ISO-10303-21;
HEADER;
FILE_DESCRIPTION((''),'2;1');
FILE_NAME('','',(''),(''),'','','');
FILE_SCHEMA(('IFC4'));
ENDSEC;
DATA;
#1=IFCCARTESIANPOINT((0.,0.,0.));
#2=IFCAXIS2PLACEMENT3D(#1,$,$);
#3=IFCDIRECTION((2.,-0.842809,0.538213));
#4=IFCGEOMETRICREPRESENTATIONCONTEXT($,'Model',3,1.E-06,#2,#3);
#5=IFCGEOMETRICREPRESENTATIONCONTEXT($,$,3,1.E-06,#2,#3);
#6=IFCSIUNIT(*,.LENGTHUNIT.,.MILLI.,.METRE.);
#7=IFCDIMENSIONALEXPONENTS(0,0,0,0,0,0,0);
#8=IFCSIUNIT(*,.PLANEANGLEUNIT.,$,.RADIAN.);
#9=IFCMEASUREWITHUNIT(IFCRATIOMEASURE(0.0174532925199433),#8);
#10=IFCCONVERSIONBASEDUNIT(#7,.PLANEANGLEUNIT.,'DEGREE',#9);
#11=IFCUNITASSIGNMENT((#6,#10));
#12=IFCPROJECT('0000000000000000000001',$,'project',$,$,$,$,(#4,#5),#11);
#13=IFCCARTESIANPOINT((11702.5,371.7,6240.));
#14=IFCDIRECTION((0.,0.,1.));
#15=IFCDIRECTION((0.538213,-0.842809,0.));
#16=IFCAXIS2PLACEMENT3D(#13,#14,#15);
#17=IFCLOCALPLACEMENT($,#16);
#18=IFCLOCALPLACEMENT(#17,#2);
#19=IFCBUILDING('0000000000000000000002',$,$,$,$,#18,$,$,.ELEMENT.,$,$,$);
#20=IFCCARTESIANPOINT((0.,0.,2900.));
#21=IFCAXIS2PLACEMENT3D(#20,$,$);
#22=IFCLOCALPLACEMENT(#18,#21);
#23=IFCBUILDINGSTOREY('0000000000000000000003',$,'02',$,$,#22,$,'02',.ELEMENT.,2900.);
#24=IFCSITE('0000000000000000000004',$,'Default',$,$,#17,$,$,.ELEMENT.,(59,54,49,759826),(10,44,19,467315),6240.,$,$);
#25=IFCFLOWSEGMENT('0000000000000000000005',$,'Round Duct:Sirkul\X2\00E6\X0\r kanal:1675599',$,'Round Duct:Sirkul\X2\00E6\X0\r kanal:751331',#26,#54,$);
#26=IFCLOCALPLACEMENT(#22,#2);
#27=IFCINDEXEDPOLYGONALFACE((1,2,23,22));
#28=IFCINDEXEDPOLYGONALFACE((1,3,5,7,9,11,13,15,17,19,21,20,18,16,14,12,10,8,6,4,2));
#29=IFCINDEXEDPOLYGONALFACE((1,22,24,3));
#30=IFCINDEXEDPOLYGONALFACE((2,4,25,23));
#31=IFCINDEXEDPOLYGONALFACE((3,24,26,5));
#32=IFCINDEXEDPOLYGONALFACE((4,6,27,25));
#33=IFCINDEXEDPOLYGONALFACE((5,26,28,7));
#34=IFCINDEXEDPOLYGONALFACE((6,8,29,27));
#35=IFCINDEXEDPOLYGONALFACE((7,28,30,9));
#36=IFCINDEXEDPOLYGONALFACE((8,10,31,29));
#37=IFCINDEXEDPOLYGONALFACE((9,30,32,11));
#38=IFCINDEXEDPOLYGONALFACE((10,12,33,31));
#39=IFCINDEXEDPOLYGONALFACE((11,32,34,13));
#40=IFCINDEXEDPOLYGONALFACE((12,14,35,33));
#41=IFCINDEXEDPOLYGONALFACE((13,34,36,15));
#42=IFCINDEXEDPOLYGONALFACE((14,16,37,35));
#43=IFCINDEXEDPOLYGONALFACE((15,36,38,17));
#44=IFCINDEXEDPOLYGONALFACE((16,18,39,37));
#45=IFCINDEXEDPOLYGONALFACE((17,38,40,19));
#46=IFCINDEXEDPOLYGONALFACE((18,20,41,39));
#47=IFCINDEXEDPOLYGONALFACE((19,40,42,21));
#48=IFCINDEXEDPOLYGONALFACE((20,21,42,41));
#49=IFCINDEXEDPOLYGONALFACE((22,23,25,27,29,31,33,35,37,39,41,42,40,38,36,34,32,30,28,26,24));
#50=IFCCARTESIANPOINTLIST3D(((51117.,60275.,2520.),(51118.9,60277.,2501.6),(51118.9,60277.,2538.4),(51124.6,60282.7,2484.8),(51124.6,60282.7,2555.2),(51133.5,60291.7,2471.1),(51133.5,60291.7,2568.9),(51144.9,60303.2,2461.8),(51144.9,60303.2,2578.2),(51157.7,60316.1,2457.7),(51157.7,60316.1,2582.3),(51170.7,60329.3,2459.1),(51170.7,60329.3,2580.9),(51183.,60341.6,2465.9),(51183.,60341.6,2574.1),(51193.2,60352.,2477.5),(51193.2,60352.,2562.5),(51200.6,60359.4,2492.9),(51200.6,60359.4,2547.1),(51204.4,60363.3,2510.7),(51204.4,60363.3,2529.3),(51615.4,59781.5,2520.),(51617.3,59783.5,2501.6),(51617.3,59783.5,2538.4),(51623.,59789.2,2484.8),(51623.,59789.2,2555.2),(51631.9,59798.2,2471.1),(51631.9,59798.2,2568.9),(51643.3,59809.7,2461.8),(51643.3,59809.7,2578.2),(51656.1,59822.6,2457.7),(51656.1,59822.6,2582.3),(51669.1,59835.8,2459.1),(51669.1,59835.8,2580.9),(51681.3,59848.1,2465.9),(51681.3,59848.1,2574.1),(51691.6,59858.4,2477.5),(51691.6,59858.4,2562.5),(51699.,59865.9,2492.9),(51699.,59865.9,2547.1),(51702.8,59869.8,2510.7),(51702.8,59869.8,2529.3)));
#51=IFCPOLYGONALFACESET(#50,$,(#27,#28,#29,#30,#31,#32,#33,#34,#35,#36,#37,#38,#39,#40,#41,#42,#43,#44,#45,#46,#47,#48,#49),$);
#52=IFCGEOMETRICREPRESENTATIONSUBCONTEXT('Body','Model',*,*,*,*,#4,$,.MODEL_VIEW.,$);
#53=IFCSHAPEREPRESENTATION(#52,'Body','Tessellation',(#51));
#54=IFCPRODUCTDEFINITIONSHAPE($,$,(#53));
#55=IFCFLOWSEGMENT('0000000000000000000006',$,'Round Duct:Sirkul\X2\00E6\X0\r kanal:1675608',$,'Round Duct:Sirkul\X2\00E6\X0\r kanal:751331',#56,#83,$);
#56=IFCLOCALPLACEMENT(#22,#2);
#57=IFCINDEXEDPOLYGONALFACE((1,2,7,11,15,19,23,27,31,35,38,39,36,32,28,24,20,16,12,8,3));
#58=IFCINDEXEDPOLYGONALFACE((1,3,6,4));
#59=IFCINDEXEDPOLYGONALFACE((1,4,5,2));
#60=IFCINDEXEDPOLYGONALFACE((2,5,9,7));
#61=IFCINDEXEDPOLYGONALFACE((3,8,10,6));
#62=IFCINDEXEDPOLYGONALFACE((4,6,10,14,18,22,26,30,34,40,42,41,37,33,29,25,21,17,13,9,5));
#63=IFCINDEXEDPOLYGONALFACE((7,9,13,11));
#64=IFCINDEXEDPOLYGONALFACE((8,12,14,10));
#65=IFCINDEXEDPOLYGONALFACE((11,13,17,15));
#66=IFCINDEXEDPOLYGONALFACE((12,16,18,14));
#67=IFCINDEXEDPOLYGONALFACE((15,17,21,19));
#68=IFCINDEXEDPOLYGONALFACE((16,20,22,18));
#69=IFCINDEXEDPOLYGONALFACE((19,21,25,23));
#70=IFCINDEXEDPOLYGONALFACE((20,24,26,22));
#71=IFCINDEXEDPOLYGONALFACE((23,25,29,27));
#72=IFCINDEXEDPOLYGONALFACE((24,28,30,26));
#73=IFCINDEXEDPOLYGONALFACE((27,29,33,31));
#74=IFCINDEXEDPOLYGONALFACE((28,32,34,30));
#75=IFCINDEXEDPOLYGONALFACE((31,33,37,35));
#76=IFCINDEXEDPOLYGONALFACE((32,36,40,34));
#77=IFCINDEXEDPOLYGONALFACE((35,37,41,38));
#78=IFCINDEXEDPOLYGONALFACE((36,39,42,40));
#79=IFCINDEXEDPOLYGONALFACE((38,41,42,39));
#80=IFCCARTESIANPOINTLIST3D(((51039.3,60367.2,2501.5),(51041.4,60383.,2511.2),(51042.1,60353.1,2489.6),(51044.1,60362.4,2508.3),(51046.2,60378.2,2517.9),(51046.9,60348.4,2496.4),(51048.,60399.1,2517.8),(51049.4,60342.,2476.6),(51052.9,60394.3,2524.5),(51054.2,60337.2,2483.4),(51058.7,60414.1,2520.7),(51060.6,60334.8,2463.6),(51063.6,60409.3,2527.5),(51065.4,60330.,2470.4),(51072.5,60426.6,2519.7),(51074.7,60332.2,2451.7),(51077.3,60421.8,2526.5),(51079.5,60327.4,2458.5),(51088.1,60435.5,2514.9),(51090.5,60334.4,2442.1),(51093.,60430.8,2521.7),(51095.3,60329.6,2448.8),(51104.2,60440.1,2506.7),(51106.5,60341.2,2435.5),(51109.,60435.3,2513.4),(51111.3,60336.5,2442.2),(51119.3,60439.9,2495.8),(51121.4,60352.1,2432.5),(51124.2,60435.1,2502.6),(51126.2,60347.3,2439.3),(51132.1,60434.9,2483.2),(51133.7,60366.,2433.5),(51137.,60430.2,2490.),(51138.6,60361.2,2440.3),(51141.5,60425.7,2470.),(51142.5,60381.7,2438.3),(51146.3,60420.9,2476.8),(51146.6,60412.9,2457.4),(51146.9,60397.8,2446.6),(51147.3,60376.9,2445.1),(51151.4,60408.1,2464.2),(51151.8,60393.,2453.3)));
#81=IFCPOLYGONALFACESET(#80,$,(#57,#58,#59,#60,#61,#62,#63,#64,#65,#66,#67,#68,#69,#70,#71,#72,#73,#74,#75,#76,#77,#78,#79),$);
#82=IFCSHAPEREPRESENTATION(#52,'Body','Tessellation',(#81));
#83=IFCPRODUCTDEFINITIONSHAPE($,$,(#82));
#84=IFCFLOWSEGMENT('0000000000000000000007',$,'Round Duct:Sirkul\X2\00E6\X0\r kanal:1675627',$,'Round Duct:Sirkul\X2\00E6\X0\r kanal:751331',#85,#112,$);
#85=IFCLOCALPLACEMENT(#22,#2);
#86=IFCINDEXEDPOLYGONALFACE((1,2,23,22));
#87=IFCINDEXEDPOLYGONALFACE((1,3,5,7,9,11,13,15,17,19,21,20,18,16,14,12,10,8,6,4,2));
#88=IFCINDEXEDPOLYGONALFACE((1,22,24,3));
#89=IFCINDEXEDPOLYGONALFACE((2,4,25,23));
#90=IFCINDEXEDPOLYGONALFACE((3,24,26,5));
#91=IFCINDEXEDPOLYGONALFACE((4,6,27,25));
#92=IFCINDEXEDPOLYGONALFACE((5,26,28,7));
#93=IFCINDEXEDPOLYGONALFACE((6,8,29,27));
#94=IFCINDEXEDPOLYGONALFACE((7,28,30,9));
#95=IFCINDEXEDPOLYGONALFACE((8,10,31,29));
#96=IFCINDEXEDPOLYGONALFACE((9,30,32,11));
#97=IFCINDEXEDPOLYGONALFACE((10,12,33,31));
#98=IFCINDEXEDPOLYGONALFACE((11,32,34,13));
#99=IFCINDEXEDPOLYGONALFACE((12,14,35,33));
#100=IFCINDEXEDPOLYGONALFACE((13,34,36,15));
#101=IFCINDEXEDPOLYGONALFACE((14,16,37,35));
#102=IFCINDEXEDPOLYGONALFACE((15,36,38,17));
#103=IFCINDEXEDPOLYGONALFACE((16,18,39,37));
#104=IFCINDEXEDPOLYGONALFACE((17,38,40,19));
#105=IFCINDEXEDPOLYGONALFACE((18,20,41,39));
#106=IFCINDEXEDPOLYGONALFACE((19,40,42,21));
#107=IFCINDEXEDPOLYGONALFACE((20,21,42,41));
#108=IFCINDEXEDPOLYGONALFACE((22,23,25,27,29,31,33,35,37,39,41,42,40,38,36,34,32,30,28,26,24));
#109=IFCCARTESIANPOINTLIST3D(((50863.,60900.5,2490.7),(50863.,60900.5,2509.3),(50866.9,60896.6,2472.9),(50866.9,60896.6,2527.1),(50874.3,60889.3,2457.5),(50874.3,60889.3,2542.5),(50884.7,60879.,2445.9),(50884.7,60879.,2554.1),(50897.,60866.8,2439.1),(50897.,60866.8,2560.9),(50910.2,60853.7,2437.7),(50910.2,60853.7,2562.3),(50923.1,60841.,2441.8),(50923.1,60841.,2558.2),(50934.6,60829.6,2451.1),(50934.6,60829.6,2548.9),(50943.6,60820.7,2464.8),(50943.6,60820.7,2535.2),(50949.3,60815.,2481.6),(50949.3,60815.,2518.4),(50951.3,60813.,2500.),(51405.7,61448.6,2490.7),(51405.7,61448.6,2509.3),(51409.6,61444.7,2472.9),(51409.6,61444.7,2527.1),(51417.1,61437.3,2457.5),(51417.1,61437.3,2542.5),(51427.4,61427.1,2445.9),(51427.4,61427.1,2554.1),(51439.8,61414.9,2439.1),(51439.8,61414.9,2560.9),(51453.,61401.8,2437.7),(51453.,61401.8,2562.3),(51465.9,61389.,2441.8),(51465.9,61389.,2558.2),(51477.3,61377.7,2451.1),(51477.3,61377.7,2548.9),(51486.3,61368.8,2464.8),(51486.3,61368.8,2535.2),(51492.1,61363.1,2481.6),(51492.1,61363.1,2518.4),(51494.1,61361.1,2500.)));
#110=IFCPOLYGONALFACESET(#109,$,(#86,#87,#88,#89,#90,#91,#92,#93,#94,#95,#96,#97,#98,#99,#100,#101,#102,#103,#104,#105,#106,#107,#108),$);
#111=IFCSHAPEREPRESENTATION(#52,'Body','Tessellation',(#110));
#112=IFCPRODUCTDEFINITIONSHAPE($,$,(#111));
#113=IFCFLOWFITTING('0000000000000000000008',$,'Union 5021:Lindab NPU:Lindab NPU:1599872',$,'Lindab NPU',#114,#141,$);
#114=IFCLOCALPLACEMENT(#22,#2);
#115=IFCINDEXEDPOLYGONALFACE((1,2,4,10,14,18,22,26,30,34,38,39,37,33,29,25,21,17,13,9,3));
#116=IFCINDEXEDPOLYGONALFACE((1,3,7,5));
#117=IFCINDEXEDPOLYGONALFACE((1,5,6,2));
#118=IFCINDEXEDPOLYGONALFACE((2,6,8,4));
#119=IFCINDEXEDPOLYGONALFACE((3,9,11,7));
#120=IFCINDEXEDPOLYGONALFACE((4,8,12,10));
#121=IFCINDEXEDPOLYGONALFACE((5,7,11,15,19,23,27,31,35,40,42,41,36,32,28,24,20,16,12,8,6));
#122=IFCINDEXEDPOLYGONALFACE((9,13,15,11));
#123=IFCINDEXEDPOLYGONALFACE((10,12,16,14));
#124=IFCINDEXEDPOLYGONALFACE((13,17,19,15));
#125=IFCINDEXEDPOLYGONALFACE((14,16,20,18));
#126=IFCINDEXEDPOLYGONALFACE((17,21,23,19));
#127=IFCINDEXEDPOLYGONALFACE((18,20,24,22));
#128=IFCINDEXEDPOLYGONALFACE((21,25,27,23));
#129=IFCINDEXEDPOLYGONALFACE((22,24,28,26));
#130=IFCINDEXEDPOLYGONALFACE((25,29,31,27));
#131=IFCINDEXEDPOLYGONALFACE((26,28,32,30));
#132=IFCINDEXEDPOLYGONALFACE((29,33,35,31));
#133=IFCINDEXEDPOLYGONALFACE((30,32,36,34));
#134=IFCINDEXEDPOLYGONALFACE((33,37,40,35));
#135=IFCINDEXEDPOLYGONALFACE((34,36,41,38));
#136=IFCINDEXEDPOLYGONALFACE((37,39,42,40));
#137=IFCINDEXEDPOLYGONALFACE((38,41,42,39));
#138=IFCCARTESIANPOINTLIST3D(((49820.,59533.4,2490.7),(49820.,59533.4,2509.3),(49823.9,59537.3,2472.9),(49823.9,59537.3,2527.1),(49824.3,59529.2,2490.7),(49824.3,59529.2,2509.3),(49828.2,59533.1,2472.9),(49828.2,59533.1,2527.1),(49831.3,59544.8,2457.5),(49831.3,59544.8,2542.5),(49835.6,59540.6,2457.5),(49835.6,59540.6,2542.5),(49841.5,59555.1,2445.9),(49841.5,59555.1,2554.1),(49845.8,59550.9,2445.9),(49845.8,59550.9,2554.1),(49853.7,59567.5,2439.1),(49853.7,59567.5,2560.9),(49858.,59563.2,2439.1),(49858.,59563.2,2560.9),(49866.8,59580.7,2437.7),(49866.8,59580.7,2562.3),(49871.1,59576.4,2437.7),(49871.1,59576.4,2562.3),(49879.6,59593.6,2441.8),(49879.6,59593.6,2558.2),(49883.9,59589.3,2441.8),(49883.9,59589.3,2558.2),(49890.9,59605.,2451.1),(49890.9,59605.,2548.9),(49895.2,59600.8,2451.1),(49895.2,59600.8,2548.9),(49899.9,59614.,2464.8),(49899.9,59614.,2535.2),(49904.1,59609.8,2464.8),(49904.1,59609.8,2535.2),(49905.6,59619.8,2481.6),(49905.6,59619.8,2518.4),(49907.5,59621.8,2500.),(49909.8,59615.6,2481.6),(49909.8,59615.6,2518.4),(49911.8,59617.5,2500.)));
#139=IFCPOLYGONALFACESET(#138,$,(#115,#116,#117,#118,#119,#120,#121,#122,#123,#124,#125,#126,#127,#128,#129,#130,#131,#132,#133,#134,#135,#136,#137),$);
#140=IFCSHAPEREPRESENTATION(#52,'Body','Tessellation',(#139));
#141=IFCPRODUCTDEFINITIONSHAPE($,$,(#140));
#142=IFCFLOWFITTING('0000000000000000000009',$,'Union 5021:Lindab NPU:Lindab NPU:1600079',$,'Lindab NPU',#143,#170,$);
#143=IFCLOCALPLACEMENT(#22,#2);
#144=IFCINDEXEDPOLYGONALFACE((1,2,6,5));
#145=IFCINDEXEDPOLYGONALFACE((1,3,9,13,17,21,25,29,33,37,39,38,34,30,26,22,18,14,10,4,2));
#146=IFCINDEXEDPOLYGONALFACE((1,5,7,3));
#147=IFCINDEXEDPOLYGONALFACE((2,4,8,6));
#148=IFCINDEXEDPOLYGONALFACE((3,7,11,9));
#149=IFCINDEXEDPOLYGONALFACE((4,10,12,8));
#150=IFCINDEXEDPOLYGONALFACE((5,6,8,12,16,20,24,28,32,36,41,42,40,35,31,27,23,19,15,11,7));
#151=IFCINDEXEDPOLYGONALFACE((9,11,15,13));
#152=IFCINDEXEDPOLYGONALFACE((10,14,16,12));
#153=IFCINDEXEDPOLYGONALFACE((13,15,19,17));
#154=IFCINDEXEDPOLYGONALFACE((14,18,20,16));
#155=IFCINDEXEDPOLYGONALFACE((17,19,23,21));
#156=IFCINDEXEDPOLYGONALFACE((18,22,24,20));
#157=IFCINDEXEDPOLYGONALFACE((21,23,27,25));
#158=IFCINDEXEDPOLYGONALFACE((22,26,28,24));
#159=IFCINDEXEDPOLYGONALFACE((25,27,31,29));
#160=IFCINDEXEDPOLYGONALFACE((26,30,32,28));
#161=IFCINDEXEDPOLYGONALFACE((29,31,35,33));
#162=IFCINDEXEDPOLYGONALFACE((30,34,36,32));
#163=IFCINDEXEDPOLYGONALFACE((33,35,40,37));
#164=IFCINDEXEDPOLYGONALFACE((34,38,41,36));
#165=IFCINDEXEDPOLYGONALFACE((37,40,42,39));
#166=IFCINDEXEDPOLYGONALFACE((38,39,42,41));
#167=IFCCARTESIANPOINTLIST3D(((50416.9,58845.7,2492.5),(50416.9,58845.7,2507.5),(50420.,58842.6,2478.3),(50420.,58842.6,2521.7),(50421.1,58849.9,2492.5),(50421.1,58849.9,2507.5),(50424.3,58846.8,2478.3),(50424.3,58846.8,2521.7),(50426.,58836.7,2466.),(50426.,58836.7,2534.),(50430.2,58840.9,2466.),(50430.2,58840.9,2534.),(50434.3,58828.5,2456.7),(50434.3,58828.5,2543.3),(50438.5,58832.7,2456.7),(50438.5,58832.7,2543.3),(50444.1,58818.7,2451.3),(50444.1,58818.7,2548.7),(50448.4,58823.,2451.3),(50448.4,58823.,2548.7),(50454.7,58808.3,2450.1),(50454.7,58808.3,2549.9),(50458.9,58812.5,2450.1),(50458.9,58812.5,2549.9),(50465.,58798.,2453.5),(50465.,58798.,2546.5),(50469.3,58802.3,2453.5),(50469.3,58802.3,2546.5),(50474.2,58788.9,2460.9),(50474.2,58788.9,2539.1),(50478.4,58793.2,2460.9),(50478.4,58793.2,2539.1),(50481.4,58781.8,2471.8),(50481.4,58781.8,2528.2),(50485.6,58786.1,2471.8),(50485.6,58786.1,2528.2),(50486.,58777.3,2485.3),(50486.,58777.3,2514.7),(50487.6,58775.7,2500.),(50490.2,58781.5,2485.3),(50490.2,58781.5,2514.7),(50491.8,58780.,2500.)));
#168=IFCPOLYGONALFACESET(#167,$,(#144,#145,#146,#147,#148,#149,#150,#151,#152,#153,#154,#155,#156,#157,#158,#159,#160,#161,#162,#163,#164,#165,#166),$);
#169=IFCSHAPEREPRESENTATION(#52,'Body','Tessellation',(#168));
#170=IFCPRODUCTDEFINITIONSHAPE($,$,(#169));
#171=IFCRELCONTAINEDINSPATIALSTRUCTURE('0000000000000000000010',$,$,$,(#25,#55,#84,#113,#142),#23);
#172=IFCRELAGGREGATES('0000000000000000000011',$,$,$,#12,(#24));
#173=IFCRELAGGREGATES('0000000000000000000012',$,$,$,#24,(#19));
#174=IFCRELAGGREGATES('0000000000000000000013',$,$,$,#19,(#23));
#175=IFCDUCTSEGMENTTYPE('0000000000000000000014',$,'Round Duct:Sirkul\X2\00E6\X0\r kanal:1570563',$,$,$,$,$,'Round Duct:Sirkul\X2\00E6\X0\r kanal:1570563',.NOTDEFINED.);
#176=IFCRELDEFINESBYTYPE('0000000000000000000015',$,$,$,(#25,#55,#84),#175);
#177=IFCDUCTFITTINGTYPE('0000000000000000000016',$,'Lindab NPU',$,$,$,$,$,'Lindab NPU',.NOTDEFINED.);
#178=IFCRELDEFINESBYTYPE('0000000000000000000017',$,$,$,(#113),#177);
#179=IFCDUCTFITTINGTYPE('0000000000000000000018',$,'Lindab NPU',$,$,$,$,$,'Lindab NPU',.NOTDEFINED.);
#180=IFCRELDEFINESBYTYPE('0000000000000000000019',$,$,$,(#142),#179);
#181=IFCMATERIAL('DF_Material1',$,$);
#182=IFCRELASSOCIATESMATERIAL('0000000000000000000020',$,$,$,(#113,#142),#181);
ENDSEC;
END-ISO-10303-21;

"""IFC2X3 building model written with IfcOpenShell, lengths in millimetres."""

from ifc_helpers import new_model, entity, si_unit, converted_unit, direction, frame, frame_2d, origin, origin_2d_with_axis, place, context, subcontext, project, spatial, circle, extrude, source, transform, mapped, material, type_object, type_shapes, element, save


model = new_model("IFC2X3")

# Units and contexts
model_context = context("Model", 3, precision=1e-06, world=origin(), true_north=direction((2.0, -0.842809, 0.538213)))
context_of_model = context(None, 3, precision=1e-06, world=origin(), true_north=direction((2.0, -0.842809, 0.538213)))
body_context = subcontext(model_context, "Body", "Model", "MODEL_VIEW")
ifc_project = project(units=[si_unit("LENGTHUNIT", "METRE", prefix="MILLI"), converted_unit("PLANEANGLEUNIT", "DEGREE", entity("IfcRatioMeasure", 0.0174532925199433), si_unit("PLANEANGLEUNIT", "RADIAN"), dimensions=[0, 0, 0, 0, 0, 0, 0])], contexts=[model_context, context_of_model])

# Site, building, storey
site_placement = place(None, frame((11702.5, 371.7, 6240.0), z_axis=(0.0, 0.0, 1.0), x_axis=(0.538213, -0.842809, 0.0)))
site = spatial("IfcSite", under=ifc_project, at=site_placement, Name="Default", CompositionType="ELEMENT", RefLatitude=(59, 54, 49, 759826), RefLongitude=(10, 44, 19, 467315), RefElevation=6240.0)
building_placement = place(site_placement, origin())
building = spatial("IfcBuilding", under=site, at=building_placement, CompositionType="ELEMENT")
storey_placement = place(building_placement, frame((0.0, 0.0, 2900.0)))
storey = spatial("IfcBuildingStorey", under=building, at=storey_placement, Name="02", LongName="02", CompositionType="ELEMENT", Elevation=2900.0)

# Flow segments
duct_segment_type_1 = type_object("IfcDuctSegmentType", Name="Round Duct:Sirkulær kanal:1570563", ElementType="Round Duct:Sirkulær kanal:1570563", PredefinedType="NOTDEFINED")
flow_segment_1_placement = place(storey_placement, origin())
element("IfcFlowSegment", 1, at=flow_segment_1_placement, inside=storey, type_object=duct_segment_type_1, Name="Round Duct:Sirkulær kanal:1675599", ObjectType="Round Duct:Sirkulær kanal:751331", context=body_context, shape_type="SweptSolid", body=[
    extrude(circle(Radius=62.5, at=origin_2d_with_axis()), frame((51659.3, 59825.9, 2520.0), z_axis=(-0.710554, 0.703643, 0.0), x_axis=(-0.703643, -0.710554, 0.0)), (0.0, 0.0, 1.0), 701.4),
])
flow_segment_2_placement = place(storey_placement, origin())
element("IfcFlowSegment", 2, at=flow_segment_2_placement, inside=storey, type_object=duct_segment_type_1, Name="Round Duct:Sirkulær kanal:1675608", ObjectType="Round Duct:Sirkulær kanal:751331", context=body_context, shape_type="SweptSolid", body=[
    extrude(circle(Radius=62.5, at=origin_2d_with_axis()), frame((51093.3, 60386.4, 2476.6), z_axis=(0.502437, -0.49755, 0.707107), x_axis=(-0.703643, -0.710554, 0.0)), (0.0, 0.0, 1.0), 9.6),
])
flow_segment_3_placement = place(storey_placement, origin())
element("IfcFlowSegment", 3, at=flow_segment_3_placement, inside=storey, type_object=duct_segment_type_1, Name="Round Duct:Sirkulær kanal:1675627", ObjectType="Round Duct:Sirkulær kanal:751331", context=body_context, shape_type="SweptSolid", body=[
    extrude(circle(Radius=62.5, at=origin_2d_with_axis()), frame((50906.9, 60857.0, 2500.0), z_axis=(0.703643, 0.710554, 0.0), x_axis=(0.710554, -0.703643, 0.0)), (0.0, 0.0, 1.0), 771.3),
])

# Flow fittings
ifc_material = material(Name="DF_Material1")
duct_fitting_type_1 = type_object("IfcDuctFittingType", Name="Lindab NPU", ElementType="Lindab NPU", PredefinedType="NOTDEFINED")
shared_shape_1 = source(origin(), body_context, "Body", "SweptSolid", [
    extrude(circle(Radius=62.5, at=frame_2d((0.0, 0.0), x_axis=(1.0, 0.0))), frame((0.0, 0.0, 0.0), z_axis=(1.0, 0.0, 0.0), x_axis=(0.0, 1.0, 0.0)), (0.0, 0.0, 1.0), 6.0),
])
type_shapes(duct_fitting_type_1, [shared_shape_1])
flow_fitting_1_placement = place(storey_placement, frame((49863.5, 59577.3, 2500.0), z_axis=(0.0, 0.0, 1.0), x_axis=(0.710554, -0.703643, 0.0)))
element("IfcFlowFitting", 4, at=flow_fitting_1_placement, inside=storey, type_object=duct_fitting_type_1, material=ifc_material, Name="Union 5021:Lindab NPU:Lindab NPU:1599872", ObjectType="Lindab NPU", context=body_context, shape_type="MappedRepresentation", body=[
    mapped(shared_shape_1, transform((0.0, 0.0, 0.0), scale=1.0)),
])
duct_fitting_type_2 = type_object("IfcDuctFittingType", Name="Lindab NPU", ElementType="Lindab NPU", PredefinedType="NOTDEFINED")
shared_shape_2 = source(origin(), body_context, "Body", "SweptSolid", [
    extrude(circle(Radius=50.0, at=frame_2d((0.0, 0.0), x_axis=(1.0, 0.0))), frame((0.0, 0.0, 0.0), z_axis=(1.0, 0.0, 0.0), x_axis=(0.0, 1.0, 0.0)), (0.0, 0.0, 1.0), 6.0),
])
type_shapes(duct_fitting_type_2, [shared_shape_2])
flow_fitting_2_placement = place(storey_placement, frame((50456.3, 58815.1, 2500.0), z_axis=(0.0, 0.0, 1.0), x_axis=(-0.703643, -0.710554, 0.0)))
element("IfcFlowFitting", 5, at=flow_fitting_2_placement, inside=storey, type_object=duct_fitting_type_2, material=ifc_material, Name="Union 5021:Lindab NPU:Lindab NPU:1600079", ObjectType="Lindab NPU", context=body_context, shape_type="MappedRepresentation", body=[
    mapped(shared_shape_2, transform((0.0, 0.0, 0.0), scale=1.0)),
])

save(model, "model.ifc")
